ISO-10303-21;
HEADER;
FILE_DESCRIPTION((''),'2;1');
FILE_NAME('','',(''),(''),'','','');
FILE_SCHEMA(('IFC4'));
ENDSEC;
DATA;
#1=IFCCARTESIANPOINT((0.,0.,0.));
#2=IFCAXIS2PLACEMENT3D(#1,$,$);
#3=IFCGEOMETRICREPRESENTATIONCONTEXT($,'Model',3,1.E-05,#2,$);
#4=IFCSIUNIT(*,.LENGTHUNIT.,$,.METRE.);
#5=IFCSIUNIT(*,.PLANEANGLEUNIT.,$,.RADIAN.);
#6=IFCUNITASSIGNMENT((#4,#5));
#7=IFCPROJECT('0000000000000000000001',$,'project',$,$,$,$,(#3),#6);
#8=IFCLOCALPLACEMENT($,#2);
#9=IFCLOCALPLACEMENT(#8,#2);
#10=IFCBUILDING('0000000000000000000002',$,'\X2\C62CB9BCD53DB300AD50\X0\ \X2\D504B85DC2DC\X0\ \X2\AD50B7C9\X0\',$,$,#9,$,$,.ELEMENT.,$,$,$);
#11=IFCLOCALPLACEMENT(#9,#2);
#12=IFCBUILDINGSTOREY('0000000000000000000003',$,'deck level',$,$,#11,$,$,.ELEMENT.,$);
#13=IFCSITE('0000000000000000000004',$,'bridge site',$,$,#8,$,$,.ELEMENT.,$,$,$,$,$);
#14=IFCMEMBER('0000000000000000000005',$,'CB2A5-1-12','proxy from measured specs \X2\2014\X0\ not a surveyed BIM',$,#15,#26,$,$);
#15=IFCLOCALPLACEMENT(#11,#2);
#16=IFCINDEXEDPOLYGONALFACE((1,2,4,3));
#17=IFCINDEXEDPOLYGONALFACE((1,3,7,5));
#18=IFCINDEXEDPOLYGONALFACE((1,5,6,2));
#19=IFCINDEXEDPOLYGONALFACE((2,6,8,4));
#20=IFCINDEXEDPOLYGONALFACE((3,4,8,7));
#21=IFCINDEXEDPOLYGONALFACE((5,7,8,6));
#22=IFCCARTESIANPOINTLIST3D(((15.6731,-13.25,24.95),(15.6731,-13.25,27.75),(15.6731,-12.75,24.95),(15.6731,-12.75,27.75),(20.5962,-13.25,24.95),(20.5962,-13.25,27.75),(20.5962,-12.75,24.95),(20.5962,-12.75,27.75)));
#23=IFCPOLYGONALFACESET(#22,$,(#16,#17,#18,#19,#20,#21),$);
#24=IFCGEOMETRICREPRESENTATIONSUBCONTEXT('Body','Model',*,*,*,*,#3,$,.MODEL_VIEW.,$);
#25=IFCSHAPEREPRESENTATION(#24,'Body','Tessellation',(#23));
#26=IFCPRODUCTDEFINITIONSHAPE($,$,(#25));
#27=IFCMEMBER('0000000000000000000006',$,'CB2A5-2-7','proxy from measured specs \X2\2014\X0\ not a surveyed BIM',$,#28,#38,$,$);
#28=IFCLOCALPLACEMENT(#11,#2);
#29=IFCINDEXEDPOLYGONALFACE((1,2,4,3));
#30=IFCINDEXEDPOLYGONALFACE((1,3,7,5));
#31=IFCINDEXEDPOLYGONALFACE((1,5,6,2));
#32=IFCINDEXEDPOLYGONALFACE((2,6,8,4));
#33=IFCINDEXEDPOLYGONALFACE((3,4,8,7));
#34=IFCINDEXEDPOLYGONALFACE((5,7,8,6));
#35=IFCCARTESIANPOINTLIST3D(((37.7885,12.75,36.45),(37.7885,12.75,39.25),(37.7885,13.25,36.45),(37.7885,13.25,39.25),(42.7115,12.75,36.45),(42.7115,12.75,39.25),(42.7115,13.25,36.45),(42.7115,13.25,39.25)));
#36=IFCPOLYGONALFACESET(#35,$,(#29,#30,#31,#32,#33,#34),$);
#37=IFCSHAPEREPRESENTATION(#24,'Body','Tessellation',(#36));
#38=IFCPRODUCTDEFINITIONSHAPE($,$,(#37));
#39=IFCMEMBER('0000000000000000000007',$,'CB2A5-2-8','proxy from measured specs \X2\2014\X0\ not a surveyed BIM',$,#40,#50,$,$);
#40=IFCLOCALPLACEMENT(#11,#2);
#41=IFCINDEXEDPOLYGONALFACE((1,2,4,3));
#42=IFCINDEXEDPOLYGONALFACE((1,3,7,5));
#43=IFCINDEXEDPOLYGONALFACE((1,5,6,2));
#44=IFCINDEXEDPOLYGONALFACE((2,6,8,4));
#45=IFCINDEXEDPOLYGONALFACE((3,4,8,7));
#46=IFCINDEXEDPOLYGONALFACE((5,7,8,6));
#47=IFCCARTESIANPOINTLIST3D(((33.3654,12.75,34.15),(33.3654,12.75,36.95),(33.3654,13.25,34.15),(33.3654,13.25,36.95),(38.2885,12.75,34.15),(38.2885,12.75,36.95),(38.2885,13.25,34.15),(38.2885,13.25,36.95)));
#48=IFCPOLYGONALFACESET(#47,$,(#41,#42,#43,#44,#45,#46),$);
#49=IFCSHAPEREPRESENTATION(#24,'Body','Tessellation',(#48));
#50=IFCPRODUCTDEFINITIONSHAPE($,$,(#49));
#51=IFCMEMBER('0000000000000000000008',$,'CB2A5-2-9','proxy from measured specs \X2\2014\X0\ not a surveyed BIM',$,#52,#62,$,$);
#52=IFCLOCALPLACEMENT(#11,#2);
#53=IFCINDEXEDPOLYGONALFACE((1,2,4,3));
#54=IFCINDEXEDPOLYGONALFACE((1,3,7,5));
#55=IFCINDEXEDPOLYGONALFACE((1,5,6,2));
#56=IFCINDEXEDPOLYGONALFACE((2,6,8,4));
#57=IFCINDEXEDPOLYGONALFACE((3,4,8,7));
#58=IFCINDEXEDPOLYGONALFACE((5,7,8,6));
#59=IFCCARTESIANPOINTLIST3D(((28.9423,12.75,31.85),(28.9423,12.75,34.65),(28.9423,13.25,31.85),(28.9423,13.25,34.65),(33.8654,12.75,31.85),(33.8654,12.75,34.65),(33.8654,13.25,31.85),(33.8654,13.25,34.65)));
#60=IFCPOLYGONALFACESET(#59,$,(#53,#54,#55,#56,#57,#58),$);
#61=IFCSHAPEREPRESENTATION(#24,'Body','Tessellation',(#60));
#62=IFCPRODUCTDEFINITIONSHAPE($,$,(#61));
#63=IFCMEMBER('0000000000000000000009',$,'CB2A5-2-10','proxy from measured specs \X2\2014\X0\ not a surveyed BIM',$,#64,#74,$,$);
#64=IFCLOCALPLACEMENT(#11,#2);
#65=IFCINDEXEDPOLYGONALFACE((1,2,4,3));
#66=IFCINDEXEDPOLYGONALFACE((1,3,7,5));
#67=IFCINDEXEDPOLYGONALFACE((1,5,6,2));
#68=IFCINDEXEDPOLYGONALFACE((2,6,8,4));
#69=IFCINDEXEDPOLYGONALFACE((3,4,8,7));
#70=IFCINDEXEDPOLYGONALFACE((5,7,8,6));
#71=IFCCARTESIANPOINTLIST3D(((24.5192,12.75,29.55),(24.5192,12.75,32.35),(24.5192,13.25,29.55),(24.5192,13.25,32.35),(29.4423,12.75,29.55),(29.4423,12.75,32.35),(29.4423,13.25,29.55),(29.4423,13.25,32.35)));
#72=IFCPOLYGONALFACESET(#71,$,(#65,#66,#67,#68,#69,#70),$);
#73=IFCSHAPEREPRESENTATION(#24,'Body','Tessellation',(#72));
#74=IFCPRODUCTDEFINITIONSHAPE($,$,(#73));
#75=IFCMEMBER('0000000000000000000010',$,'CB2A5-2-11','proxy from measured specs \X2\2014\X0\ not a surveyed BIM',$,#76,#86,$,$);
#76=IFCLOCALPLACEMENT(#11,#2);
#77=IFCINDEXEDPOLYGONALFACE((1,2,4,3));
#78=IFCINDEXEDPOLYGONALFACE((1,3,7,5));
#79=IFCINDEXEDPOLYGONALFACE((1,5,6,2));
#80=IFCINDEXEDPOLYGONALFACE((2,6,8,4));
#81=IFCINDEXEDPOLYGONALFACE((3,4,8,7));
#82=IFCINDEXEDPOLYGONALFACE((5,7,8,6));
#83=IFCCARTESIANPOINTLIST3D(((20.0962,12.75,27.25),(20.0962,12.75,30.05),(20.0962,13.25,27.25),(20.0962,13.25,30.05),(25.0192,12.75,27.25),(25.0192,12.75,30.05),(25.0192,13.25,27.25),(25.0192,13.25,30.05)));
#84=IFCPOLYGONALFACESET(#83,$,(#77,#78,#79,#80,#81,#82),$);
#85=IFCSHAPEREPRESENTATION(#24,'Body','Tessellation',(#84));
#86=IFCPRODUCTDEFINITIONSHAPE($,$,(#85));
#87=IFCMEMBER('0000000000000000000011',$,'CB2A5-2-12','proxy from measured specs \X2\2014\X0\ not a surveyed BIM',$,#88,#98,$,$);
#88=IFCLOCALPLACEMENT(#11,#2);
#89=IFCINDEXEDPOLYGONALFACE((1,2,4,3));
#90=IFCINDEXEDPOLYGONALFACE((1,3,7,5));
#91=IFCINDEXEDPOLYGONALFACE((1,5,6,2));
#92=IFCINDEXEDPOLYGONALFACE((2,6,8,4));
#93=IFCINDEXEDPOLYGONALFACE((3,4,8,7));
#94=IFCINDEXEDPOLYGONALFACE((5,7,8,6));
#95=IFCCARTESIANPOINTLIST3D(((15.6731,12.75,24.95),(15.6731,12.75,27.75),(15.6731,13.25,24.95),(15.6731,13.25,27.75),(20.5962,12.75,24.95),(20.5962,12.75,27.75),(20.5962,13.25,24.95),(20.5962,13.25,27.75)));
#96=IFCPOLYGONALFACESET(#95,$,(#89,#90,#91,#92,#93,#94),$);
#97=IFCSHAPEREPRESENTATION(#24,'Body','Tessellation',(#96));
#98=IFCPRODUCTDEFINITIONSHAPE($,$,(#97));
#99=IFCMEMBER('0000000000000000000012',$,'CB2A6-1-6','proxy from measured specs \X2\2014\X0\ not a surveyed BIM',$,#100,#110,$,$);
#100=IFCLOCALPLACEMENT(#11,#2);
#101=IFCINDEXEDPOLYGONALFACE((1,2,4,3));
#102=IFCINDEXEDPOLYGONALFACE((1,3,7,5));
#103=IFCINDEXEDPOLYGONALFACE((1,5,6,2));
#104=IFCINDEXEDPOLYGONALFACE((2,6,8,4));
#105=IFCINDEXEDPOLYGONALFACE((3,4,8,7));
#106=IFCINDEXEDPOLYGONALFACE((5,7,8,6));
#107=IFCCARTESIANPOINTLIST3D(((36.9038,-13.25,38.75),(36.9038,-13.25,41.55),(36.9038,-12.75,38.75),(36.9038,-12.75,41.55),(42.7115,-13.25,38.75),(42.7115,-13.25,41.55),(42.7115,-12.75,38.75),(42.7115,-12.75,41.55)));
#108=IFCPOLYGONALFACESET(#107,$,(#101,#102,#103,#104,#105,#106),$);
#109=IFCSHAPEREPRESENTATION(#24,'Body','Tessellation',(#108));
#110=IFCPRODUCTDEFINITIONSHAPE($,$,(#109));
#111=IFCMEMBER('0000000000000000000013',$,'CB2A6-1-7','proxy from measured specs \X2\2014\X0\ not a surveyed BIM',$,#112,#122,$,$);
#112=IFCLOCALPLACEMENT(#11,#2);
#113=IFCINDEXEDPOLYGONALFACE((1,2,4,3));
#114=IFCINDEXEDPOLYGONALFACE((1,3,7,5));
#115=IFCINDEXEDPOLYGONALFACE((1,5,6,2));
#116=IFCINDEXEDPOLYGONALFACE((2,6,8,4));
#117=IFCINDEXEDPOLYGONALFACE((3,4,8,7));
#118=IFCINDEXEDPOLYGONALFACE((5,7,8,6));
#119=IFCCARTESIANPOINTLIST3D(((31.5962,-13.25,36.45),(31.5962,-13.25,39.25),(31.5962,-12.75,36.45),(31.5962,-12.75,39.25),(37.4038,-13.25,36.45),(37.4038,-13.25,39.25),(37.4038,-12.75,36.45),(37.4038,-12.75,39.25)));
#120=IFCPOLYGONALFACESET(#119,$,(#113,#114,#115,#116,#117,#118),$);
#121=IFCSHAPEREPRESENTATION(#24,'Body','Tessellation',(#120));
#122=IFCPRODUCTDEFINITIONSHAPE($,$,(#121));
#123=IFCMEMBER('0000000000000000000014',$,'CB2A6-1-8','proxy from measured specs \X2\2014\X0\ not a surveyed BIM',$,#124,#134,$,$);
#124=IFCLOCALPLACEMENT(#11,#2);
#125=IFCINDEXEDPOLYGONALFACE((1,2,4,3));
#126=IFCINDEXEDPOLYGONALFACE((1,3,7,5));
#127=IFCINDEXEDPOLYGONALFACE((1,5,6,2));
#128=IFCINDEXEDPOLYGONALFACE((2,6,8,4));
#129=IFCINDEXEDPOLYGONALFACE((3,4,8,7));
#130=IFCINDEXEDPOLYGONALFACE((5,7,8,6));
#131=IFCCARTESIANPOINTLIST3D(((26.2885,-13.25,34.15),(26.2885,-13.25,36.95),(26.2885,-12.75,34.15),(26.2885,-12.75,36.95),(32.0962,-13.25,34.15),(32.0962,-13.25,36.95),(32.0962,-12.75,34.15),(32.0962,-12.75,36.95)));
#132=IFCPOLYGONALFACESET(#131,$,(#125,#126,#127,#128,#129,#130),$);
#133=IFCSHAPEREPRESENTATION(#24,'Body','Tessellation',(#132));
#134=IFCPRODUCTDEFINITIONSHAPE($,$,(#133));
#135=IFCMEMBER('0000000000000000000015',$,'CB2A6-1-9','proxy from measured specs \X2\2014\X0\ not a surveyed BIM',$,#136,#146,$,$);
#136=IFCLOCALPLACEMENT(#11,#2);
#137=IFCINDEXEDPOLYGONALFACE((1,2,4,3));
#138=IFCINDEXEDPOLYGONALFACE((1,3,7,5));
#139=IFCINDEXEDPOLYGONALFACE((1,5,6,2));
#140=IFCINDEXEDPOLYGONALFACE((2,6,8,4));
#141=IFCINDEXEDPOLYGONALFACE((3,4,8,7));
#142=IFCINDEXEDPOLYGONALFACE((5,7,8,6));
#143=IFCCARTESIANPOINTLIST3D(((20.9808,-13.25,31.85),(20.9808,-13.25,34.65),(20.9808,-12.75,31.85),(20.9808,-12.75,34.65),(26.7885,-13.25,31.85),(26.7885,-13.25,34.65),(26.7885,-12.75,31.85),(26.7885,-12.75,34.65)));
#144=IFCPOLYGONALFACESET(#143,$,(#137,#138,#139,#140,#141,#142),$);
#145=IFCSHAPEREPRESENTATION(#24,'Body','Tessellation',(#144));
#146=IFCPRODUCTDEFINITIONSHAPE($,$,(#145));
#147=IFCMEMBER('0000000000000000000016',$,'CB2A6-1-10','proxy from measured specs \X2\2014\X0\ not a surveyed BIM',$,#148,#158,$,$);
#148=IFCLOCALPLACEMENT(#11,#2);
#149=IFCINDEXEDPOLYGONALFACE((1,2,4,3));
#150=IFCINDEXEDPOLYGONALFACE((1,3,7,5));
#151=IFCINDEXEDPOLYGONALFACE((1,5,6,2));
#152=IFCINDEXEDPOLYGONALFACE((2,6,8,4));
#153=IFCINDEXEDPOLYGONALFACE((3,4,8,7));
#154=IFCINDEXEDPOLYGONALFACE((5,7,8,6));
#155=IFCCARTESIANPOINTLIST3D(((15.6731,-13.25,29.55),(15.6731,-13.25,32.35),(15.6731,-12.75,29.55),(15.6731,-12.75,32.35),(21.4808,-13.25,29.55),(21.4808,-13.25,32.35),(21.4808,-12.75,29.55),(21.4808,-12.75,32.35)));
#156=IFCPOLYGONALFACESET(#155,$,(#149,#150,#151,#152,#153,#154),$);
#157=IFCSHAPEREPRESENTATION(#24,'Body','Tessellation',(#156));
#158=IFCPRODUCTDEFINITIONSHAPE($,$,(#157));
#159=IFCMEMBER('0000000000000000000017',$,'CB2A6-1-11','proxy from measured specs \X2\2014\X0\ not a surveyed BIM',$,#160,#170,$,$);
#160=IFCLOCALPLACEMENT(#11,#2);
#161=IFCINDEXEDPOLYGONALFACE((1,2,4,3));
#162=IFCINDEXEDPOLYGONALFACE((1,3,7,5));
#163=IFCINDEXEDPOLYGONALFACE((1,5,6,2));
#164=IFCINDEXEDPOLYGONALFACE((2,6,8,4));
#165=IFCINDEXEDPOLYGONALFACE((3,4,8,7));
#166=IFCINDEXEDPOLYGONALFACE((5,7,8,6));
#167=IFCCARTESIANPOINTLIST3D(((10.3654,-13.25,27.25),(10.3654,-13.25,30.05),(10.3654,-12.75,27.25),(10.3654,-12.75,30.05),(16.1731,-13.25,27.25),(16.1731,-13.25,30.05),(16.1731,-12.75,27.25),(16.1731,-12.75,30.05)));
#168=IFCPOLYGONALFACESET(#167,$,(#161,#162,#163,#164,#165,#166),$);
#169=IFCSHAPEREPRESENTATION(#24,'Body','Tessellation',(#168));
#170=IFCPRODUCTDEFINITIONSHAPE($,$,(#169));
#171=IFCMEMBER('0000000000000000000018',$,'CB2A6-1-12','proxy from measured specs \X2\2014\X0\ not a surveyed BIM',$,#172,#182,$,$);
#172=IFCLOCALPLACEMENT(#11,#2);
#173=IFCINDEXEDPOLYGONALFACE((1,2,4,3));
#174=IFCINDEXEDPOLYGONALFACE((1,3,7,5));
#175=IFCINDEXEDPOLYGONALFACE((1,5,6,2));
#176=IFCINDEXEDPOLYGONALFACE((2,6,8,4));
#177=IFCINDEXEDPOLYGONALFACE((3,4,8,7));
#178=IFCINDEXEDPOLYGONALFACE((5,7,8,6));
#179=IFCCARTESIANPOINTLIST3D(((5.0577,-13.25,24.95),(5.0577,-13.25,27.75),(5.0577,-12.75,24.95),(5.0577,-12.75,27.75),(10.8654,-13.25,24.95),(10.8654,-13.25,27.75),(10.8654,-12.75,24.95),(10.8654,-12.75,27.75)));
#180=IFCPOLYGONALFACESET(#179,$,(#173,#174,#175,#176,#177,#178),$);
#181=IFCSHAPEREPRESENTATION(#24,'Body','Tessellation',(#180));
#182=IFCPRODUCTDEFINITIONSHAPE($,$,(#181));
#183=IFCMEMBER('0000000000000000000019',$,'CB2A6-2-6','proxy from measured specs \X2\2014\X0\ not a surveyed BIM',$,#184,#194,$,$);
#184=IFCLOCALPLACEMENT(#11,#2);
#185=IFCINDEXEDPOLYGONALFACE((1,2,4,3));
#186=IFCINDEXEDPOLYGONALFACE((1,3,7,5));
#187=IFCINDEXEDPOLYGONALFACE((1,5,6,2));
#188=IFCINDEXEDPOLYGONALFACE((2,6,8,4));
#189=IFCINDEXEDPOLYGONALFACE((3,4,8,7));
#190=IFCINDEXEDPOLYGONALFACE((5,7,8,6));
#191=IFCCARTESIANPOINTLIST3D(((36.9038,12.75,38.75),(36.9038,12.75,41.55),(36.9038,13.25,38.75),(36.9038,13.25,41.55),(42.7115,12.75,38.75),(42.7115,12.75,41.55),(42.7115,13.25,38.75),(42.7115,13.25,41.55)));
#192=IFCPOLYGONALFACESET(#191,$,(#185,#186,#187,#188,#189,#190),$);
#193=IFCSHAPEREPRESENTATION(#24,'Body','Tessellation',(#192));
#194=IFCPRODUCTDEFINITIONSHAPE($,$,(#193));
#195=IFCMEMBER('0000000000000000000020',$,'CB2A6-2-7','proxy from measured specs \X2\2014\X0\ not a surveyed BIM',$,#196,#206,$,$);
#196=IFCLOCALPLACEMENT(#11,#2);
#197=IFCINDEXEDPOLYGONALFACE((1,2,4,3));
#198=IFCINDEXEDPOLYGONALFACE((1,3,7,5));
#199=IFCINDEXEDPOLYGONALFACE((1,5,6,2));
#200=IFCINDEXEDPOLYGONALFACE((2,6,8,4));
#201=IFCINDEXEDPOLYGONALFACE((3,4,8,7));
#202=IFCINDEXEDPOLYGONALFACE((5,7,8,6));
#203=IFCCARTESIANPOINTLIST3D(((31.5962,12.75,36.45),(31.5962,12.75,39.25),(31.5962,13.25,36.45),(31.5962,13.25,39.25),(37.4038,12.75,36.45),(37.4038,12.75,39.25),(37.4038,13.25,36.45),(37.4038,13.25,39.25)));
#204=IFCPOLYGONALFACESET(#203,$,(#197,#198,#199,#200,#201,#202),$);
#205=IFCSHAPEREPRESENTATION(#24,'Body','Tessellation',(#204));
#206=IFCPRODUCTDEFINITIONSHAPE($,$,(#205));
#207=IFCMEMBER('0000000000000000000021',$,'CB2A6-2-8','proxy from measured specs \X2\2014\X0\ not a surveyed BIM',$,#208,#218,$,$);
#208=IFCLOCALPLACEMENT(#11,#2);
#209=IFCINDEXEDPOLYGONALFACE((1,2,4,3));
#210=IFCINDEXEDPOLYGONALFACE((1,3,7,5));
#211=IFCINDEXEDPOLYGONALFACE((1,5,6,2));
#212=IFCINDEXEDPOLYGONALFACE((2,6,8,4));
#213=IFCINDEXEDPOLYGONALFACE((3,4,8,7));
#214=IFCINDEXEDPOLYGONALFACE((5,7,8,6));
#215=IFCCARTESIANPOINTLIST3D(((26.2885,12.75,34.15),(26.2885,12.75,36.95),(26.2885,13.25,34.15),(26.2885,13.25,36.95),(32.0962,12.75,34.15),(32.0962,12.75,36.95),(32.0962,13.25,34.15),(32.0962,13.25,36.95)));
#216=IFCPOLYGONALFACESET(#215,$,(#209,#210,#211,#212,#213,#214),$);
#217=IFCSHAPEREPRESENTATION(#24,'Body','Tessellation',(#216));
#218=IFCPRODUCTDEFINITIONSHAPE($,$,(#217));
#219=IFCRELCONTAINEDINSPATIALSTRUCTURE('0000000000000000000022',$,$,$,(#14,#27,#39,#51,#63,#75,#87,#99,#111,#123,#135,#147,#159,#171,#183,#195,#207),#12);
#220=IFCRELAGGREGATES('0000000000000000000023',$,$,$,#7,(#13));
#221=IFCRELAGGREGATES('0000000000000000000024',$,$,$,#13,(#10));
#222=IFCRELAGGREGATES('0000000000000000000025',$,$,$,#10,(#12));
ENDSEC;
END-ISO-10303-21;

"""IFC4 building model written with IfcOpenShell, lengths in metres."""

from ifc_helpers import new_model, si_unit, frame, origin, origin_2d, place, context, subcontext, project, spatial, rectangle, extrude, element, save


model = new_model("IFC4")

# Units and contexts
model_context = context("Model", 3, precision=1e-05, world=origin())
body_context = subcontext(model_context, "Body", "Model", "MODEL_VIEW")
ifc_project = project(units=[si_unit("LENGTHUNIT", "METRE"), si_unit("PLANEANGLEUNIT", "RADIAN")], contexts=[model_context])

# Site, building, storey
site_placement = place(None, origin())
site = spatial("IfcSite", under=ifc_project, at=site_placement, Name="bridge site", CompositionType="ELEMENT")
building_placement = place(site_placement, origin())
building = spatial("IfcBuilding", under=site, at=building_placement, Name="올림픽대교 프록시 교량", CompositionType="ELEMENT")
storey_placement = place(building_placement, origin())
storey = spatial("IfcBuildingStorey", under=building, at=storey_placement, Name="deck level", CompositionType="ELEMENT")

# Members
member_1_placement = place(storey_placement, frame((18.1346, -13.0, 24.95)))
element("IfcMember", 1, at=member_1_placement, inside=storey, Name="CB2A5-1-12", Description="proxy from measured specs — not a surveyed BIM", context=body_context, shape_type="SweptSolid", body=[
    extrude(rectangle(XDim=4.9231, YDim=0.5, at=origin_2d()), origin(), (0.0, 0.0, 1.0), 2.8),
])
member_2_placement = place(storey_placement, frame((40.25, 13.0, 36.45)))
element("IfcMember", 2, at=member_2_placement, inside=storey, Name="CB2A5-2-7", Description="proxy from measured specs — not a surveyed BIM", context=body_context, shape_type="SweptSolid", body=[
    extrude(rectangle(XDim=4.9231, YDim=0.5, at=origin_2d()), origin(), (0.0, 0.0, 1.0), 2.8),
])
member_3_placement = place(storey_placement, frame((35.8269, 13.0, 34.15)))
element("IfcMember", 3, at=member_3_placement, inside=storey, Name="CB2A5-2-8", Description="proxy from measured specs — not a surveyed BIM", context=body_context, shape_type="SweptSolid", body=[
    extrude(rectangle(XDim=4.9231, YDim=0.5, at=origin_2d()), origin(), (0.0, 0.0, 1.0), 2.8),
])
member_4_placement = place(storey_placement, frame((31.4038, 13.0, 31.85)))
element("IfcMember", 4, at=member_4_placement, inside=storey, Name="CB2A5-2-9", Description="proxy from measured specs — not a surveyed BIM", context=body_context, shape_type="SweptSolid", body=[
    extrude(rectangle(XDim=4.9231, YDim=0.5, at=origin_2d()), origin(), (0.0, 0.0, 1.0), 2.8),
])
member_5_placement = place(storey_placement, frame((26.9808, 13.0, 29.55)))
element("IfcMember", 5, at=member_5_placement, inside=storey, Name="CB2A5-2-10", Description="proxy from measured specs — not a surveyed BIM", context=body_context, shape_type="SweptSolid", body=[
    extrude(rectangle(XDim=4.9231, YDim=0.5, at=origin_2d()), origin(), (0.0, 0.0, 1.0), 2.8),
])
member_6_placement = place(storey_placement, frame((22.5577, 13.0, 27.25)))
element("IfcMember", 6, at=member_6_placement, inside=storey, Name="CB2A5-2-11", Description="proxy from measured specs — not a surveyed BIM", context=body_context, shape_type="SweptSolid", body=[
    extrude(rectangle(XDim=4.9231, YDim=0.5, at=origin_2d()), origin(), (0.0, 0.0, 1.0), 2.8),
])
member_7_placement = place(storey_placement, frame((18.1346, 13.0, 24.95)))
element("IfcMember", 7, at=member_7_placement, inside=storey, Name="CB2A5-2-12", Description="proxy from measured specs — not a surveyed BIM", context=body_context, shape_type="SweptSolid", body=[
    extrude(rectangle(XDim=4.9231, YDim=0.5, at=origin_2d()), origin(), (0.0, 0.0, 1.0), 2.8),
])
member_8_placement = place(storey_placement, frame((39.8077, -13.0, 38.75)))
element("IfcMember", 8, at=member_8_placement, inside=storey, Name="CB2A6-1-6", Description="proxy from measured specs — not a surveyed BIM", context=body_context, shape_type="SweptSolid", body=[
    extrude(rectangle(XDim=5.8077, YDim=0.5, at=origin_2d()), origin(), (0.0, 0.0, 1.0), 2.8),
])
member_9_placement = place(storey_placement, frame((34.5, -13.0, 36.45)))
element("IfcMember", 9, at=member_9_placement, inside=storey, Name="CB2A6-1-7", Description="proxy from measured specs — not a surveyed BIM", context=body_context, shape_type="SweptSolid", body=[
    extrude(rectangle(XDim=5.8077, YDim=0.5, at=origin_2d()), origin(), (0.0, 0.0, 1.0), 2.8),
])
member_10_placement = place(storey_placement, frame((29.1923, -13.0, 34.15)))
element("IfcMember", 10, at=member_10_placement, inside=storey, Name="CB2A6-1-8", Description="proxy from measured specs — not a surveyed BIM", context=body_context, shape_type="SweptSolid", body=[
    extrude(rectangle(XDim=5.8077, YDim=0.5, at=origin_2d()), origin(), (0.0, 0.0, 1.0), 2.8),
])
member_11_placement = place(storey_placement, frame((23.8846, -13.0, 31.85)))
element("IfcMember", 11, at=member_11_placement, inside=storey, Name="CB2A6-1-9", Description="proxy from measured specs — not a surveyed BIM", context=body_context, shape_type="SweptSolid", body=[
    extrude(rectangle(XDim=5.8077, YDim=0.5, at=origin_2d()), origin(), (0.0, 0.0, 1.0), 2.8),
])
member_12_placement = place(storey_placement, frame((18.5769, -13.0, 29.55)))
element("IfcMember", 12, at=member_12_placement, inside=storey, Name="CB2A6-1-10", Description="proxy from measured specs — not a surveyed BIM", context=body_context, shape_type="SweptSolid", body=[
    extrude(rectangle(XDim=5.8077, YDim=0.5, at=origin_2d()), origin(), (0.0, 0.0, 1.0), 2.8),
])
member_13_placement = place(storey_placement, frame((13.2692, -13.0, 27.25)))
element("IfcMember", 13, at=member_13_placement, inside=storey, Name="CB2A6-1-11", Description="proxy from measured specs — not a surveyed BIM", context=body_context, shape_type="SweptSolid", body=[
    extrude(rectangle(XDim=5.8077, YDim=0.5, at=origin_2d()), origin(), (0.0, 0.0, 1.0), 2.8),
])
member_14_placement = place(storey_placement, frame((7.9615, -13.0, 24.95)))
element("IfcMember", 14, at=member_14_placement, inside=storey, Name="CB2A6-1-12", Description="proxy from measured specs — not a surveyed BIM", context=body_context, shape_type="SweptSolid", body=[
    extrude(rectangle(XDim=5.8077, YDim=0.5, at=origin_2d()), origin(), (0.0, 0.0, 1.0), 2.8),
])
member_15_placement = place(storey_placement, frame((39.8077, 13.0, 38.75)))
element("IfcMember", 15, at=member_15_placement, inside=storey, Name="CB2A6-2-6", Description="proxy from measured specs — not a surveyed BIM", context=body_context, shape_type="SweptSolid", body=[
    extrude(rectangle(XDim=5.8077, YDim=0.5, at=origin_2d()), origin(), (0.0, 0.0, 1.0), 2.8),
])
member_16_placement = place(storey_placement, frame((34.5, 13.0, 36.45)))
element("IfcMember", 16, at=member_16_placement, inside=storey, Name="CB2A6-2-7", Description="proxy from measured specs — not a surveyed BIM", context=body_context, shape_type="SweptSolid", body=[
    extrude(rectangle(XDim=5.8077, YDim=0.5, at=origin_2d()), origin(), (0.0, 0.0, 1.0), 2.8),
])
member_17_placement = place(storey_placement, frame((29.1923, 13.0, 34.15)))
element("IfcMember", 17, at=member_17_placement, inside=storey, Name="CB2A6-2-8", Description="proxy from measured specs — not a surveyed BIM", context=body_context, shape_type="SweptSolid", body=[
    extrude(rectangle(XDim=5.8077, YDim=0.5, at=origin_2d()), origin(), (0.0, 0.0, 1.0), 2.8),
])

save(model, "model.ifc")
